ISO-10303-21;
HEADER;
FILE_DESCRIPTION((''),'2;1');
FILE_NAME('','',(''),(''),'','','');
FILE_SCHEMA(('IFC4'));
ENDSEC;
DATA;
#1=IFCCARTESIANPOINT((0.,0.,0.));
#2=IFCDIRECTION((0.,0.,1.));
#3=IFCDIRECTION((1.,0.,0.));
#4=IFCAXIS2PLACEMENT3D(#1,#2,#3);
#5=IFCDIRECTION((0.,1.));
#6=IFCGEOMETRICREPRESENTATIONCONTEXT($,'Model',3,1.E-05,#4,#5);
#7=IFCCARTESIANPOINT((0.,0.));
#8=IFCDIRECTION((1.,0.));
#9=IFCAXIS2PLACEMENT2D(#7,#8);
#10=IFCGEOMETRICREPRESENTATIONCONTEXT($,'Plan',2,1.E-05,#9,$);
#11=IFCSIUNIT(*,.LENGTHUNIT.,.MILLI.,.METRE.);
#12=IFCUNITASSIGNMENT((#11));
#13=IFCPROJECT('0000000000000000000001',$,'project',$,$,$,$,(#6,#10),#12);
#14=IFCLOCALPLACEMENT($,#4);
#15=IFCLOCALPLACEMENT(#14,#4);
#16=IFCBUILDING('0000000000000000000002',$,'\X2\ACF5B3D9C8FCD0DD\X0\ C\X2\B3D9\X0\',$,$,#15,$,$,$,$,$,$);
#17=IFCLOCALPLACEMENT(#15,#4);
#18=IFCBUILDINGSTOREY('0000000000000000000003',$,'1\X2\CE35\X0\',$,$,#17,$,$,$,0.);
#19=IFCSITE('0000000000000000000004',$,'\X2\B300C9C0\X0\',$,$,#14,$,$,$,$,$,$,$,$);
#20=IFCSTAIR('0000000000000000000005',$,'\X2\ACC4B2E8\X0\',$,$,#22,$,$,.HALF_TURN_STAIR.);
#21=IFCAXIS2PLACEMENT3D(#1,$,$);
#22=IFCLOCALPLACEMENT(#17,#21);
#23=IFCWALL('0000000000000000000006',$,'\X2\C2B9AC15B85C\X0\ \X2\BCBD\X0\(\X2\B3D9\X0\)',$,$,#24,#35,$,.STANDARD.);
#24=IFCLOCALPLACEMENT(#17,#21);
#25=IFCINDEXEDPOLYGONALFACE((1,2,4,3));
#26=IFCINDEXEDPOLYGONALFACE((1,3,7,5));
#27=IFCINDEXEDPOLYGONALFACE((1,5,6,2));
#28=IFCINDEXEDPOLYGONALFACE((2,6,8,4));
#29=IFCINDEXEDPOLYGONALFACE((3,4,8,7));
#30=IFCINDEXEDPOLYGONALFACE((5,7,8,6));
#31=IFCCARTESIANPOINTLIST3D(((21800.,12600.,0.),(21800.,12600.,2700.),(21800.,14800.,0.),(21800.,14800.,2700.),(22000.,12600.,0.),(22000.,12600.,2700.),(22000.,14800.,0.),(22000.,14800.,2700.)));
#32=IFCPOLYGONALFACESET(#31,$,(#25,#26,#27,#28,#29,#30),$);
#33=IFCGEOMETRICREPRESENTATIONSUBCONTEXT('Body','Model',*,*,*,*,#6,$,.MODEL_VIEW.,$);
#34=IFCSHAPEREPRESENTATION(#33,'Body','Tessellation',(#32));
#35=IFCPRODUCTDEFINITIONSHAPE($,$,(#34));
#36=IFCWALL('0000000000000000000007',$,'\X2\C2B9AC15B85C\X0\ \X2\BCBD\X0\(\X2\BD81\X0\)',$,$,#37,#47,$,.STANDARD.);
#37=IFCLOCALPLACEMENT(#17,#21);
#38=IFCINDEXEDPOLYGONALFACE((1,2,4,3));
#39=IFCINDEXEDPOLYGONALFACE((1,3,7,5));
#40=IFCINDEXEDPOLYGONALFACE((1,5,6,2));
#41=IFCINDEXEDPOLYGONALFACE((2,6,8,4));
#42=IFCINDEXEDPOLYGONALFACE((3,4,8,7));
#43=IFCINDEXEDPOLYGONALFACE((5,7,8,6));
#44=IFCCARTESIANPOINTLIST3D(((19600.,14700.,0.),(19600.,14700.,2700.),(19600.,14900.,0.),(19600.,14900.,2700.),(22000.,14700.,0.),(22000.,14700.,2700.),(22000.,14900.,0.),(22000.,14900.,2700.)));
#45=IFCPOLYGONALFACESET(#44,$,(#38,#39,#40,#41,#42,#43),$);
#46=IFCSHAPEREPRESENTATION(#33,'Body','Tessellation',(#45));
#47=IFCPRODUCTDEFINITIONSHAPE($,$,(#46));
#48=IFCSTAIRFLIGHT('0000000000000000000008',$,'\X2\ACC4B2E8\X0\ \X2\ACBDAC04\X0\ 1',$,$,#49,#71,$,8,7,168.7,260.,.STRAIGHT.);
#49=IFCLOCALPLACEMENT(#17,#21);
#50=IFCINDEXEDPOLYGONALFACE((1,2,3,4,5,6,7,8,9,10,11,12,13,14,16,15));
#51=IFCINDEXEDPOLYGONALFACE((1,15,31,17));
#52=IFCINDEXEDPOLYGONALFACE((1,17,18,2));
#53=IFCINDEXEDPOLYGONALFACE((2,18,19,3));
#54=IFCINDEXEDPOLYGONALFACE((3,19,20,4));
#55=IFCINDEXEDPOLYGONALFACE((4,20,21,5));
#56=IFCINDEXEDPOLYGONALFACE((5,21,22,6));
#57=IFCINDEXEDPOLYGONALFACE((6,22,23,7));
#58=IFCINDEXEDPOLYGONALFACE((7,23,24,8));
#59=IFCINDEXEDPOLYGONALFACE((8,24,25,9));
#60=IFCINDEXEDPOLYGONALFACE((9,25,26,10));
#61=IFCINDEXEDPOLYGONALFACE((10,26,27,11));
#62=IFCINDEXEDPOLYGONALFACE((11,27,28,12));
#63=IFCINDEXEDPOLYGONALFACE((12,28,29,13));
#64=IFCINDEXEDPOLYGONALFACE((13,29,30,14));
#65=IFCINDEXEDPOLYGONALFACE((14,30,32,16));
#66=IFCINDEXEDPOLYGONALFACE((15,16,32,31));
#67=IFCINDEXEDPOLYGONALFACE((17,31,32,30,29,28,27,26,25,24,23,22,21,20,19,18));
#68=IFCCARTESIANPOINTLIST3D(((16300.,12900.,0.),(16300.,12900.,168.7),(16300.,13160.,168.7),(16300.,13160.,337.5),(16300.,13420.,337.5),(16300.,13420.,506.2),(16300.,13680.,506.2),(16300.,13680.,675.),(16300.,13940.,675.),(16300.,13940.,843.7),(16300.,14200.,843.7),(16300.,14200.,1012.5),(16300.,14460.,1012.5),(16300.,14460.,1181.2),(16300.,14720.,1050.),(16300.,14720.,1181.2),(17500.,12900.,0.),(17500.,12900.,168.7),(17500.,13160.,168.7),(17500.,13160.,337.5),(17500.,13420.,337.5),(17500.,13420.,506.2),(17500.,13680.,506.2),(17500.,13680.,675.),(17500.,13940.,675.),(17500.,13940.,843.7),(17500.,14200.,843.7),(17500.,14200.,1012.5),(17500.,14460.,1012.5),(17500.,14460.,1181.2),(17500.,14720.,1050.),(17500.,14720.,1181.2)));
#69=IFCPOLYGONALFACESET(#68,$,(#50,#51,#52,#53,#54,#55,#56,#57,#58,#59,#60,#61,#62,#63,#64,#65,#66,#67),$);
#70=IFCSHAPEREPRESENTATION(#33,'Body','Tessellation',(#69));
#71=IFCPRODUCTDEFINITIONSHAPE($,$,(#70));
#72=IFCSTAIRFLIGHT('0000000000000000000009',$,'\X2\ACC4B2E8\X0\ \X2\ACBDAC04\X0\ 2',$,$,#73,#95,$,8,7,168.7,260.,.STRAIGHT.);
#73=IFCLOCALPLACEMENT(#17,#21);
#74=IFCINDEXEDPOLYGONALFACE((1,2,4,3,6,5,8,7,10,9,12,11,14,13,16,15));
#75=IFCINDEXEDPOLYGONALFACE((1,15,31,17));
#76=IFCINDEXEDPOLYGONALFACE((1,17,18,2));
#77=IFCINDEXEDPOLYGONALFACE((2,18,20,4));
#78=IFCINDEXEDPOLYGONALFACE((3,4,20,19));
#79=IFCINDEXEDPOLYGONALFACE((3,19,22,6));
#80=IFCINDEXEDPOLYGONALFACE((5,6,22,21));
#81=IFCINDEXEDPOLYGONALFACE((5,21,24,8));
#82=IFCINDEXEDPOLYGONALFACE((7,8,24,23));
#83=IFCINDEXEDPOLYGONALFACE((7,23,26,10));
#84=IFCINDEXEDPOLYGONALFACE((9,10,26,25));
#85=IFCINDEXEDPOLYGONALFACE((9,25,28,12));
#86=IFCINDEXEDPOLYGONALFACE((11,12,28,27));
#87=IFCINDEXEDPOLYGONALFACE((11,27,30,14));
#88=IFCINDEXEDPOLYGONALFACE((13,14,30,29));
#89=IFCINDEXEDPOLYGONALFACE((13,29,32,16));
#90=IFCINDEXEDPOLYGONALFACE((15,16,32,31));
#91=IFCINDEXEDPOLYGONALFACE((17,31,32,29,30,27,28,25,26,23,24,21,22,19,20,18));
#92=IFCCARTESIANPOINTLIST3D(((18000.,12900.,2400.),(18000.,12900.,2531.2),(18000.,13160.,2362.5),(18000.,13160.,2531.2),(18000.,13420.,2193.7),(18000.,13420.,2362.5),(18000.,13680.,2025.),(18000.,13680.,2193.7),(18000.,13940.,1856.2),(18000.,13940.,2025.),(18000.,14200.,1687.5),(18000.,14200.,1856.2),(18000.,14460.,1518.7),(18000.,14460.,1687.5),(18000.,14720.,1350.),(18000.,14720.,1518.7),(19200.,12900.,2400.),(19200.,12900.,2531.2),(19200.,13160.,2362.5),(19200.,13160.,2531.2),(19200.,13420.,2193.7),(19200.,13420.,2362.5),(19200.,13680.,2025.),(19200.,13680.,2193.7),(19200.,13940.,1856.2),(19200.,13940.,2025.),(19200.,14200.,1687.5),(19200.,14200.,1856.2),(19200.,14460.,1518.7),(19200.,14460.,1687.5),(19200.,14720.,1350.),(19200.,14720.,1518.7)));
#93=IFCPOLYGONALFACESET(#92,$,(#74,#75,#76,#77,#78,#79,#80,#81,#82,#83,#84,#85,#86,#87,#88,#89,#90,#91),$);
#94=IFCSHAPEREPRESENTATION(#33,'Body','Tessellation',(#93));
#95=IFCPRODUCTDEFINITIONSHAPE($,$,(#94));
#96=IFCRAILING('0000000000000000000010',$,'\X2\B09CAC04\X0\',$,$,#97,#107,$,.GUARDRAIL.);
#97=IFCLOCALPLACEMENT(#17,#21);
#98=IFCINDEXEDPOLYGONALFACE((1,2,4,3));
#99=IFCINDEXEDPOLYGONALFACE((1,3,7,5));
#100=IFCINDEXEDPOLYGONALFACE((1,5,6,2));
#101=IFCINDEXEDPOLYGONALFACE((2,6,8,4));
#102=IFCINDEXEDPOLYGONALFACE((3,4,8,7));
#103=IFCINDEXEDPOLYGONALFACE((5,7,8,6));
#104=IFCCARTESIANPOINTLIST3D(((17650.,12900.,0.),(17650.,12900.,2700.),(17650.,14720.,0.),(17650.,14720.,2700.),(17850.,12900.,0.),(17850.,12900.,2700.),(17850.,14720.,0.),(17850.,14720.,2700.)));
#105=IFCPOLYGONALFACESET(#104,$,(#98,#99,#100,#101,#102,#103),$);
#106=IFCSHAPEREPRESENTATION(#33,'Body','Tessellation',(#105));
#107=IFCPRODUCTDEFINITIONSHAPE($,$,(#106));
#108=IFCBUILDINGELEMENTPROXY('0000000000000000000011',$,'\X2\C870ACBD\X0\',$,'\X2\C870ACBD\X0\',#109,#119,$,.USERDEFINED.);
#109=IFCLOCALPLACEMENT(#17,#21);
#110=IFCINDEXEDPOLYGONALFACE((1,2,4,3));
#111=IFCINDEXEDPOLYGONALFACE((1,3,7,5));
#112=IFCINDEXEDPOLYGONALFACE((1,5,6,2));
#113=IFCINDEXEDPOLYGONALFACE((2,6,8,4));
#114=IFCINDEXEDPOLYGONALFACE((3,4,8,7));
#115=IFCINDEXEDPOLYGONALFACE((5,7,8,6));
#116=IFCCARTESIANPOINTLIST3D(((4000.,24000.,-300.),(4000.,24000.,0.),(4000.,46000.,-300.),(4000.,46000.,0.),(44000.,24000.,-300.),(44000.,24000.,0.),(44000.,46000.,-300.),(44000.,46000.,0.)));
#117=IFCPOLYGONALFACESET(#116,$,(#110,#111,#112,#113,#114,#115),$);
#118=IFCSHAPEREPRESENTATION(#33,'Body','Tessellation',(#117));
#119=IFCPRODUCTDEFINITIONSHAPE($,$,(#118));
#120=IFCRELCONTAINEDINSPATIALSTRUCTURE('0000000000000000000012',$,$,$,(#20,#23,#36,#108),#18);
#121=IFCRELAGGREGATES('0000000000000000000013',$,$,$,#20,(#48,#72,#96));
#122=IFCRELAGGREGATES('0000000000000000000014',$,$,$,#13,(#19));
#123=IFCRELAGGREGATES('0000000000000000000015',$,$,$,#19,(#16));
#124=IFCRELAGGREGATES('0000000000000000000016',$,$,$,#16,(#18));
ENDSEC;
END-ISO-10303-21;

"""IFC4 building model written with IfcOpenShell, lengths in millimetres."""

from ifc_helpers import new_model, si_unit, direction, frame, origin_with_axes, origin_2d_with_axis, place, context, subcontext, project, spatial, polyline, outline, extrude, element, aggregate, save


model = new_model("IFC4")

# Units and contexts
model_context = context("Model", 3, precision=1e-05, world=origin_with_axes(), true_north=direction((0.0, 1.0)))
plan_context = context("Plan", 2, precision=1e-05, world=origin_2d_with_axis())
body_context = subcontext(model_context, "Body", "Model", "MODEL_VIEW")
ifc_project = project(units=[si_unit("LENGTHUNIT", "METRE", prefix="MILLI")], contexts=[model_context, plan_context])

# Site, building, storey
site_placement = place(None, origin_with_axes())
site = spatial("IfcSite", under=ifc_project, at=site_placement, Name="대지")
building_placement = place(site_placement, origin_with_axes())
building = spatial("IfcBuilding", under=site, at=building_placement, Name="공동주택 C동")
storey_placement = place(building_placement, origin_with_axes())
storey = spatial("IfcBuildingStorey", under=building, at=storey_placement, Name="1층", Elevation=0.0)

# Stair
stair_placement = place(storey_placement, origin_with_axes())
stair = element("IfcStair", 1, at=stair_placement, inside=storey, Name="계단", PredefinedType="HALF_TURN_STAIR")

# Walls
wall_1_placement = place(storey_placement, origin_with_axes())
element("IfcWall", 2, at=wall_1_placement, inside=storey, Name="승강로 벽(동)", PredefinedType="STANDARD", context=body_context, shape_type="SweptSolid", body=[
    extrude(outline(polyline([(21800.0, 12600.0), (21800.0, 14800.0), (22000.0, 14800.0), (22000.0, 12600.0), (21800.0, 12600.0)])), origin_with_axes(), (0.0, 0.0, 1.0), 2700.0),
])
wall_2_placement = place(storey_placement, origin_with_axes())
element("IfcWall", 3, at=wall_2_placement, inside=storey, Name="승강로 벽(북)", PredefinedType="STANDARD", context=body_context, shape_type="SweptSolid", body=[
    extrude(outline(polyline([(19600.0, 14900.0), (22000.0, 14900.0), (22000.0, 14700.0), (19600.0, 14700.0), (19600.0, 14900.0)])), origin_with_axes(), (0.0, 0.0, 1.0), 2700.0),
])

# Stair flights
stair_flight_1_placement = place(stair_placement, origin_with_axes())
stair_flight_1 = element("IfcStairFlight", 4, at=stair_flight_1_placement, Name="계단 경간 1", NumberOfRisers=8, NumberOfTreads=7, PredefinedType="STRAIGHT", RiserHeight=168.7, TreadLength=260.0, context=body_context, shape_type="SweptSolid", body=[
    extrude(outline(polyline([(0.0, 0.0), (0.0, 168.7), (260.0, 168.7), (260.0, 337.5), (520.0, 337.5), (520.0, 506.2), (780.0, 506.2), (780.0, 675.0), (1040.0, 675.0), (1040.0, 843.7), (1300.0, 843.7), (1300.0, 1012.5), (1560.0, 1012.5), (1560.0, 1181.2), (1820.0, 1181.2), (1820.0, 1350.0), (1820.0, 1050.0), (0.0, 0.0)])), frame((16300.0, 12900.0, 0.0), z_axis=(1.0, 0.0, 0.0), x_axis=(0.0, 1.0, 0.0)), (0.0, 0.0, 1.0), 1200.0),
])
stair_flight_2_placement = place(stair_placement, origin_with_axes())
stair_flight_2 = element("IfcStairFlight", 5, at=stair_flight_2_placement, Name="계단 경간 2", NumberOfRisers=8, NumberOfTreads=7, PredefinedType="STRAIGHT", RiserHeight=168.7, TreadLength=260.0, context=body_context, shape_type="SweptSolid", body=[
    extrude(outline(polyline([(0.0, 0.0), (0.0, 168.7), (260.0, 168.7), (260.0, 337.5), (520.0, 337.5), (520.0, 506.2), (780.0, 506.2), (780.0, 675.0), (1040.0, 675.0), (1040.0, 843.7), (1300.0, 843.7), (1300.0, 1012.5), (1560.0, 1012.5), (1560.0, 1181.2), (1820.0, 1181.2), (1820.0, 1350.0), (1820.0, 1050.0), (0.0, 0.0)])), frame((19200.0, 14720.0, 1350.0), z_axis=(-1.0, 0.0, 0.0), x_axis=(0.0, -1.0, 0.0)), (0.0, 0.0, 1.0), 1200.0),
])

# Railing
railing_placement = place(stair_placement, origin_with_axes())
railing = element("IfcRailing", 6, at=railing_placement, Name="난간", PredefinedType="GUARDRAIL", context=body_context, shape_type="SweptSolid", body=[
    extrude(outline(polyline([(17650.0, 12900.0), (17850.0, 12900.0), (17850.0, 14720.0), (17650.0, 14720.0), (17650.0, 12900.0)])), origin_with_axes(), (0.0, 0.0, 1.0), 2700.0),
])
aggregate(stair, [stair_flight_1, stair_flight_2, railing])

# Building element proxy
proxy_placement = place(storey_placement, origin_with_axes())
element("IfcBuildingElementProxy", 7, at=proxy_placement, inside=storey, Name="조경", ObjectType="조경", PredefinedType="USERDEFINED", context=body_context, shape_type="SweptSolid", body=[
    extrude(outline(polyline([(4000.0, 24000.0), (44000.0, 24000.0), (44000.0, 46000.0), (4000.0, 46000.0), (4000.0, 24000.0)])), frame((0.0, 0.0, -300.0), z_axis=(0.0, 0.0, 1.0), x_axis=(1.0, 0.0, 0.0)), (0.0, 0.0, 1.0), 300.0),
])

save(model, "model.ifc")
